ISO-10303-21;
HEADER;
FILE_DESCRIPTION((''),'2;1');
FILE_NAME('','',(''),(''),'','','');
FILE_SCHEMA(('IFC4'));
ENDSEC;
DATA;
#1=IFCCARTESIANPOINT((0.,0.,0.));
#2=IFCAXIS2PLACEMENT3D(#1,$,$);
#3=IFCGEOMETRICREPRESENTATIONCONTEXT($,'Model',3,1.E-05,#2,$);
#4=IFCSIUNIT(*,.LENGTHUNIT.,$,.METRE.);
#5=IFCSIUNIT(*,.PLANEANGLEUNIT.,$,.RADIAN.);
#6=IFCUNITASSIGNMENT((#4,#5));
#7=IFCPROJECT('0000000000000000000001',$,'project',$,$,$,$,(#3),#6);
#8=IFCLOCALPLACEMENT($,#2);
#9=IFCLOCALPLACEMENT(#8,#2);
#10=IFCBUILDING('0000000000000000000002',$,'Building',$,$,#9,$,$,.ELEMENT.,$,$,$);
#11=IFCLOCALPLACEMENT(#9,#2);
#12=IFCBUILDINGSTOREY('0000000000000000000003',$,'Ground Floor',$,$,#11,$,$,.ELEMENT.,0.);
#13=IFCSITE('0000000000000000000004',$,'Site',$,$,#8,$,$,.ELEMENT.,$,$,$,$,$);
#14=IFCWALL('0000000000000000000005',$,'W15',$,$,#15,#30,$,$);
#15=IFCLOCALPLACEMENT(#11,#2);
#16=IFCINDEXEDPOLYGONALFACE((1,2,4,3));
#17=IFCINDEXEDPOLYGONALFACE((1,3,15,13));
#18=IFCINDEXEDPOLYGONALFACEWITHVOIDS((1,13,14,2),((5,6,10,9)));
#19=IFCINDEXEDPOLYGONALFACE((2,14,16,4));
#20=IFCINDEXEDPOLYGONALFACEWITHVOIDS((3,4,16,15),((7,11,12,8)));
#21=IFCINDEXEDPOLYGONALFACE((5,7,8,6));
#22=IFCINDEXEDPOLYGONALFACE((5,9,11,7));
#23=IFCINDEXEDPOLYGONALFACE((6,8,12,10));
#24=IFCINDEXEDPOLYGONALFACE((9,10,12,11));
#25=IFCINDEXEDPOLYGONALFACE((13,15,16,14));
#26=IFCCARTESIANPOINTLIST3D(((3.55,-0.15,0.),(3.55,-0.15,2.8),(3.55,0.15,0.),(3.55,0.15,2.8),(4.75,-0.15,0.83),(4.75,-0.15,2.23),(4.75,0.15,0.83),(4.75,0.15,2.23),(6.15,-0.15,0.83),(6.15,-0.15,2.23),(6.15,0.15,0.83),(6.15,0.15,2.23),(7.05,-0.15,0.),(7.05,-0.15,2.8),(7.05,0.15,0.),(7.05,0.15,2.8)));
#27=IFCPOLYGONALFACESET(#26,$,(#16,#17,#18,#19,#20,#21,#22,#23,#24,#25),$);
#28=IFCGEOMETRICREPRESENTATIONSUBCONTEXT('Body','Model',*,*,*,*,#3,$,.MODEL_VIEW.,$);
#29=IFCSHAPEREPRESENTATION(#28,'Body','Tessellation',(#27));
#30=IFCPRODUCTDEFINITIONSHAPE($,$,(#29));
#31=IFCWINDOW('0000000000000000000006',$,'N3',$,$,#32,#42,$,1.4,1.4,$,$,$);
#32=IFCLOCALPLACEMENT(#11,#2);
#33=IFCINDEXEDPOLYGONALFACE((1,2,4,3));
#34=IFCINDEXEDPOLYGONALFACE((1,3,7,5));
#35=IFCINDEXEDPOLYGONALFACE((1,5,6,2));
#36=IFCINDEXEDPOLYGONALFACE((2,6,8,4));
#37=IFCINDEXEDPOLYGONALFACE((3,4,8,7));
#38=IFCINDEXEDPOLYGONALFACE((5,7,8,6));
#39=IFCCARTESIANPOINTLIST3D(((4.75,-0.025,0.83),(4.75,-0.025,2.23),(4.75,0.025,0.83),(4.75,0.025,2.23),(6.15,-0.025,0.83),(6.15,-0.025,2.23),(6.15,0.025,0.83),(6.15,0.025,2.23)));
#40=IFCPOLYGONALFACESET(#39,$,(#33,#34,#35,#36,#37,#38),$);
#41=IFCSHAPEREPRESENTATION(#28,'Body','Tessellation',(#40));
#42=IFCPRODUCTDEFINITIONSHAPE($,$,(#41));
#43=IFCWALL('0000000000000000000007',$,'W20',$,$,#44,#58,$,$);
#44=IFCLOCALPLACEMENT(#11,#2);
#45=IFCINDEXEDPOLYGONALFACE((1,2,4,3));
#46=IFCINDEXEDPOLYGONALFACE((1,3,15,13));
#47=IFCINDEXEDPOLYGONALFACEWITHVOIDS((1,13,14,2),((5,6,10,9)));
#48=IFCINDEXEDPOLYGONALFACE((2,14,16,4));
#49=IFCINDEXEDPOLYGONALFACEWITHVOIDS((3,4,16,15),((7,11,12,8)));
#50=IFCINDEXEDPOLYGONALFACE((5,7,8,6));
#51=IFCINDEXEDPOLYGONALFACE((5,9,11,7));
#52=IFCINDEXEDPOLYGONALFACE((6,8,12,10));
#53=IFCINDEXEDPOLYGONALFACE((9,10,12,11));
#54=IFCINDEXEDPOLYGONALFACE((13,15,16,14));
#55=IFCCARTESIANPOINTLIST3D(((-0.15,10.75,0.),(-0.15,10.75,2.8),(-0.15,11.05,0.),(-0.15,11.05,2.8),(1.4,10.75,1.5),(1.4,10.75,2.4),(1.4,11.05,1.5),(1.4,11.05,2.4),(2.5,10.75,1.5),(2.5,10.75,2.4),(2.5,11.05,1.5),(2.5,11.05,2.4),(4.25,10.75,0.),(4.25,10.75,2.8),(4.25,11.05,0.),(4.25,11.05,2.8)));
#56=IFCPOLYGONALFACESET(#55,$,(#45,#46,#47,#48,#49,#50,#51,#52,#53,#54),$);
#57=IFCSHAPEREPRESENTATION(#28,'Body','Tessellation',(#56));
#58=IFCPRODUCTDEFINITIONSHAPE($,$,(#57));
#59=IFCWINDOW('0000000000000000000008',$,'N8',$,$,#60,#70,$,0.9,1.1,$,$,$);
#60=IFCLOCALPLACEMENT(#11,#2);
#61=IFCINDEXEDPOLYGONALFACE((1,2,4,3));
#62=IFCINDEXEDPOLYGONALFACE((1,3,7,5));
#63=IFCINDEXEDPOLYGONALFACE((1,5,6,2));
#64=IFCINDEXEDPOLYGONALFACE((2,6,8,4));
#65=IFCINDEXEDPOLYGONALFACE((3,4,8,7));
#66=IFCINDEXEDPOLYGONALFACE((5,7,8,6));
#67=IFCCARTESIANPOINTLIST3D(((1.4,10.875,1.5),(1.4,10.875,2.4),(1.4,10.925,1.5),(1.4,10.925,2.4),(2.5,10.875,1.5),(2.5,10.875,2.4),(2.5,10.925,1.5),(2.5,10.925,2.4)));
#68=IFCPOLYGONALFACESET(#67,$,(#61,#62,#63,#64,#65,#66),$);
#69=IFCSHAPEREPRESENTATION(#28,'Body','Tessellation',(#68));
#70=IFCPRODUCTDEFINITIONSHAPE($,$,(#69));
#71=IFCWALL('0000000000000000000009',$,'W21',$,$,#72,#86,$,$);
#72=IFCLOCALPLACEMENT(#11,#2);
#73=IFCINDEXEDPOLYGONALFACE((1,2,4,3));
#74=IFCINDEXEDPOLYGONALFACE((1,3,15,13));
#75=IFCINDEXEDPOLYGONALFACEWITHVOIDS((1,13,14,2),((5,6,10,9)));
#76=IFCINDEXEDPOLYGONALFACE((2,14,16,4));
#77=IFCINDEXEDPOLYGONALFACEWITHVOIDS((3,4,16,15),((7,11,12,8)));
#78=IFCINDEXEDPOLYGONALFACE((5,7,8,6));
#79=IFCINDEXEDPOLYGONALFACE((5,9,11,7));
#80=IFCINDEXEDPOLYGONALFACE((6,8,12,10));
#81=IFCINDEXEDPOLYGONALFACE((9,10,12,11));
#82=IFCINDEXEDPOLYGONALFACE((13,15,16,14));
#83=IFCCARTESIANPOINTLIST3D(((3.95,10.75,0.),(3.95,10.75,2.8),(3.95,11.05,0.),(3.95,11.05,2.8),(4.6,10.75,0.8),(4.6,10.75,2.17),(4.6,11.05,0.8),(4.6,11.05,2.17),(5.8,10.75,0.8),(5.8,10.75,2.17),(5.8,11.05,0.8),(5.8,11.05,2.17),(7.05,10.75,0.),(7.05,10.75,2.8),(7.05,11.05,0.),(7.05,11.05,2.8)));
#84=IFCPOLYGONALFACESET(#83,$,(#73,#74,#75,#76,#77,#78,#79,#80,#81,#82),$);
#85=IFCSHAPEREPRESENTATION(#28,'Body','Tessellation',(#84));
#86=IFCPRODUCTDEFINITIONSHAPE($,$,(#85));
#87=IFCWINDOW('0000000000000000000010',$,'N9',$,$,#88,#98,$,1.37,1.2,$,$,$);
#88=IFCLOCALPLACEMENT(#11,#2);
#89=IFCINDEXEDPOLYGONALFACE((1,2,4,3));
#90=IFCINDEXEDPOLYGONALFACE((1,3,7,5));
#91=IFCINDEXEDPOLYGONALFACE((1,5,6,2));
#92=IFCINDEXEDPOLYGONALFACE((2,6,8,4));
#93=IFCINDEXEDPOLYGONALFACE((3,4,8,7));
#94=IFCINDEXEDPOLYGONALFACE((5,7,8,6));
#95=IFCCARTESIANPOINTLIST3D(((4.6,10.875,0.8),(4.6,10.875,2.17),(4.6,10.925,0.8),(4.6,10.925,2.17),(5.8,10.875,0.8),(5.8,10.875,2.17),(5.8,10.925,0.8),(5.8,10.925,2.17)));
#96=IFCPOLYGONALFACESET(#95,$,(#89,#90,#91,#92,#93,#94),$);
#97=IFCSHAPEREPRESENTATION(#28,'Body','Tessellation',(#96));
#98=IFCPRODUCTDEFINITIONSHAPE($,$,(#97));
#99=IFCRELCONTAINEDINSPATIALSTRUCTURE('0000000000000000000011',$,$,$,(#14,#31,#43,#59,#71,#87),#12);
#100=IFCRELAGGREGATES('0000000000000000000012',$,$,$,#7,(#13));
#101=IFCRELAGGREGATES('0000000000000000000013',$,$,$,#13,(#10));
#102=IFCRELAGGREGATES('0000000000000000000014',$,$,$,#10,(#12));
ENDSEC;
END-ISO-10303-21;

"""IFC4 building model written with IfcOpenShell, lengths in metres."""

from ifc_helpers import new_model, si_unit, frame, frame_2d, origin, origin_2d, place, context, subcontext, project, spatial, rectangle, extrude, element, fill, save


model = new_model("IFC4")

# Units and contexts
model_context = context("Model", 3, precision=1e-05, world=origin())
body_context = subcontext(model_context, "Body", "Model", "MODEL_VIEW")
ifc_project = project(units=[si_unit("LENGTHUNIT", "METRE"), si_unit("PLANEANGLEUNIT", "RADIAN")], contexts=[model_context])

# Site, building, storey
site_placement = place(None, origin())
site = spatial("IfcSite", under=ifc_project, at=site_placement, Name="Site", CompositionType="ELEMENT")
building_placement = place(site_placement, origin())
building = spatial("IfcBuilding", under=site, at=building_placement, Name="Building", CompositionType="ELEMENT")
storey_placement = place(building_placement, origin())
storey = spatial("IfcBuildingStorey", under=building, at=storey_placement, Name="Ground Floor", CompositionType="ELEMENT", Elevation=0.0)

# Wall, opening, window
wall_1_placement = place(storey_placement, frame((3.7, 0.0, 0.0), x_axis=(1.0, 0.0, 0.0)))
wall_1 = element("IfcWall", 1, at=wall_1_placement, inside=storey, Name="W15", context=body_context, shape_type="SweptSolid", body=[
    extrude(rectangle(XDim=3.5, YDim=0.3, at=frame_2d((1.6, 0.0))), origin(), (0.0, 0.0, 1.0), 2.8),
])
opening_1_placement = place(wall_1_placement, frame((1.75, 0.0, 0.83)))
opening_1 = element("IfcOpeningElement", 2, at=opening_1_placement, cuts=wall_1, context=body_context, shape_type="SweptSolid", body=[
    extrude(rectangle(XDim=1.4, YDim=0.4, at=origin_2d()), origin(), (0.0, 0.0, 1.0), 1.4),
])
window_1_placement = place(opening_1_placement, origin())
window_1 = element("IfcWindow", 3, at=window_1_placement, inside=storey, Name="N3", OverallHeight=1.4, OverallWidth=1.4, context=body_context, shape_type="SweptSolid", body=[
    extrude(rectangle(XDim=1.4, YDim=0.05, at=origin_2d()), origin(), (0.0, 0.0, 1.0), 1.4),
])
fill(opening_1, window_1)

# Walls, openings, windows
wall_2_placement = place(storey_placement, frame((0.0, 10.9, 0.0), x_axis=(1.0, 0.0, 0.0)))
wall_2 = element("IfcWall", 4, at=wall_2_placement, inside=storey, Name="W20", context=body_context, shape_type="SweptSolid", body=[
    extrude(rectangle(XDim=4.4, YDim=0.3, at=frame_2d((2.05, 0.0))), origin(), (0.0, 0.0, 1.0), 2.8),
])
opening_2_placement = place(wall_2_placement, frame((1.95, 0.0, 1.5)))
opening_2 = element("IfcOpeningElement", 5, at=opening_2_placement, cuts=wall_2, context=body_context, shape_type="SweptSolid", body=[
    extrude(rectangle(XDim=1.1, YDim=0.4, at=origin_2d()), origin(), (0.0, 0.0, 1.0), 0.9),
])
window_2_placement = place(opening_2_placement, origin())
window_2 = element("IfcWindow", 6, at=window_2_placement, inside=storey, Name="N8", OverallHeight=0.9, OverallWidth=1.1, context=body_context, shape_type="SweptSolid", body=[
    extrude(rectangle(XDim=1.1, YDim=0.05, at=origin_2d()), origin(), (0.0, 0.0, 1.0), 0.9),
])
fill(opening_2, window_2)
wall_3_placement = place(storey_placement, frame((4.1, 10.9, 0.0), x_axis=(1.0, 0.0, 0.0)))
wall_3 = element("IfcWall", 7, at=wall_3_placement, inside=storey, Name="W21", context=body_context, shape_type="SweptSolid", body=[
    extrude(rectangle(XDim=3.1, YDim=0.3, at=frame_2d((1.4, 0.0))), origin(), (0.0, 0.0, 1.0), 2.8),
])
opening_3_placement = place(wall_3_placement, frame((1.1, 0.0, 0.8)))
opening_3 = element("IfcOpeningElement", 8, at=opening_3_placement, cuts=wall_3, context=body_context, shape_type="SweptSolid", body=[
    extrude(rectangle(XDim=1.2, YDim=0.4, at=origin_2d()), origin(), (0.0, 0.0, 1.0), 1.37),
])
window_3_placement = place(opening_3_placement, origin())
window_3 = element("IfcWindow", 9, at=window_3_placement, inside=storey, Name="N9", OverallHeight=1.37, OverallWidth=1.2, context=body_context, shape_type="SweptSolid", body=[
    extrude(rectangle(XDim=1.2, YDim=0.05, at=origin_2d()), origin(), (0.0, 0.0, 1.0), 1.37),
])
fill(opening_3, window_3)

save(model, "model.ifc")
